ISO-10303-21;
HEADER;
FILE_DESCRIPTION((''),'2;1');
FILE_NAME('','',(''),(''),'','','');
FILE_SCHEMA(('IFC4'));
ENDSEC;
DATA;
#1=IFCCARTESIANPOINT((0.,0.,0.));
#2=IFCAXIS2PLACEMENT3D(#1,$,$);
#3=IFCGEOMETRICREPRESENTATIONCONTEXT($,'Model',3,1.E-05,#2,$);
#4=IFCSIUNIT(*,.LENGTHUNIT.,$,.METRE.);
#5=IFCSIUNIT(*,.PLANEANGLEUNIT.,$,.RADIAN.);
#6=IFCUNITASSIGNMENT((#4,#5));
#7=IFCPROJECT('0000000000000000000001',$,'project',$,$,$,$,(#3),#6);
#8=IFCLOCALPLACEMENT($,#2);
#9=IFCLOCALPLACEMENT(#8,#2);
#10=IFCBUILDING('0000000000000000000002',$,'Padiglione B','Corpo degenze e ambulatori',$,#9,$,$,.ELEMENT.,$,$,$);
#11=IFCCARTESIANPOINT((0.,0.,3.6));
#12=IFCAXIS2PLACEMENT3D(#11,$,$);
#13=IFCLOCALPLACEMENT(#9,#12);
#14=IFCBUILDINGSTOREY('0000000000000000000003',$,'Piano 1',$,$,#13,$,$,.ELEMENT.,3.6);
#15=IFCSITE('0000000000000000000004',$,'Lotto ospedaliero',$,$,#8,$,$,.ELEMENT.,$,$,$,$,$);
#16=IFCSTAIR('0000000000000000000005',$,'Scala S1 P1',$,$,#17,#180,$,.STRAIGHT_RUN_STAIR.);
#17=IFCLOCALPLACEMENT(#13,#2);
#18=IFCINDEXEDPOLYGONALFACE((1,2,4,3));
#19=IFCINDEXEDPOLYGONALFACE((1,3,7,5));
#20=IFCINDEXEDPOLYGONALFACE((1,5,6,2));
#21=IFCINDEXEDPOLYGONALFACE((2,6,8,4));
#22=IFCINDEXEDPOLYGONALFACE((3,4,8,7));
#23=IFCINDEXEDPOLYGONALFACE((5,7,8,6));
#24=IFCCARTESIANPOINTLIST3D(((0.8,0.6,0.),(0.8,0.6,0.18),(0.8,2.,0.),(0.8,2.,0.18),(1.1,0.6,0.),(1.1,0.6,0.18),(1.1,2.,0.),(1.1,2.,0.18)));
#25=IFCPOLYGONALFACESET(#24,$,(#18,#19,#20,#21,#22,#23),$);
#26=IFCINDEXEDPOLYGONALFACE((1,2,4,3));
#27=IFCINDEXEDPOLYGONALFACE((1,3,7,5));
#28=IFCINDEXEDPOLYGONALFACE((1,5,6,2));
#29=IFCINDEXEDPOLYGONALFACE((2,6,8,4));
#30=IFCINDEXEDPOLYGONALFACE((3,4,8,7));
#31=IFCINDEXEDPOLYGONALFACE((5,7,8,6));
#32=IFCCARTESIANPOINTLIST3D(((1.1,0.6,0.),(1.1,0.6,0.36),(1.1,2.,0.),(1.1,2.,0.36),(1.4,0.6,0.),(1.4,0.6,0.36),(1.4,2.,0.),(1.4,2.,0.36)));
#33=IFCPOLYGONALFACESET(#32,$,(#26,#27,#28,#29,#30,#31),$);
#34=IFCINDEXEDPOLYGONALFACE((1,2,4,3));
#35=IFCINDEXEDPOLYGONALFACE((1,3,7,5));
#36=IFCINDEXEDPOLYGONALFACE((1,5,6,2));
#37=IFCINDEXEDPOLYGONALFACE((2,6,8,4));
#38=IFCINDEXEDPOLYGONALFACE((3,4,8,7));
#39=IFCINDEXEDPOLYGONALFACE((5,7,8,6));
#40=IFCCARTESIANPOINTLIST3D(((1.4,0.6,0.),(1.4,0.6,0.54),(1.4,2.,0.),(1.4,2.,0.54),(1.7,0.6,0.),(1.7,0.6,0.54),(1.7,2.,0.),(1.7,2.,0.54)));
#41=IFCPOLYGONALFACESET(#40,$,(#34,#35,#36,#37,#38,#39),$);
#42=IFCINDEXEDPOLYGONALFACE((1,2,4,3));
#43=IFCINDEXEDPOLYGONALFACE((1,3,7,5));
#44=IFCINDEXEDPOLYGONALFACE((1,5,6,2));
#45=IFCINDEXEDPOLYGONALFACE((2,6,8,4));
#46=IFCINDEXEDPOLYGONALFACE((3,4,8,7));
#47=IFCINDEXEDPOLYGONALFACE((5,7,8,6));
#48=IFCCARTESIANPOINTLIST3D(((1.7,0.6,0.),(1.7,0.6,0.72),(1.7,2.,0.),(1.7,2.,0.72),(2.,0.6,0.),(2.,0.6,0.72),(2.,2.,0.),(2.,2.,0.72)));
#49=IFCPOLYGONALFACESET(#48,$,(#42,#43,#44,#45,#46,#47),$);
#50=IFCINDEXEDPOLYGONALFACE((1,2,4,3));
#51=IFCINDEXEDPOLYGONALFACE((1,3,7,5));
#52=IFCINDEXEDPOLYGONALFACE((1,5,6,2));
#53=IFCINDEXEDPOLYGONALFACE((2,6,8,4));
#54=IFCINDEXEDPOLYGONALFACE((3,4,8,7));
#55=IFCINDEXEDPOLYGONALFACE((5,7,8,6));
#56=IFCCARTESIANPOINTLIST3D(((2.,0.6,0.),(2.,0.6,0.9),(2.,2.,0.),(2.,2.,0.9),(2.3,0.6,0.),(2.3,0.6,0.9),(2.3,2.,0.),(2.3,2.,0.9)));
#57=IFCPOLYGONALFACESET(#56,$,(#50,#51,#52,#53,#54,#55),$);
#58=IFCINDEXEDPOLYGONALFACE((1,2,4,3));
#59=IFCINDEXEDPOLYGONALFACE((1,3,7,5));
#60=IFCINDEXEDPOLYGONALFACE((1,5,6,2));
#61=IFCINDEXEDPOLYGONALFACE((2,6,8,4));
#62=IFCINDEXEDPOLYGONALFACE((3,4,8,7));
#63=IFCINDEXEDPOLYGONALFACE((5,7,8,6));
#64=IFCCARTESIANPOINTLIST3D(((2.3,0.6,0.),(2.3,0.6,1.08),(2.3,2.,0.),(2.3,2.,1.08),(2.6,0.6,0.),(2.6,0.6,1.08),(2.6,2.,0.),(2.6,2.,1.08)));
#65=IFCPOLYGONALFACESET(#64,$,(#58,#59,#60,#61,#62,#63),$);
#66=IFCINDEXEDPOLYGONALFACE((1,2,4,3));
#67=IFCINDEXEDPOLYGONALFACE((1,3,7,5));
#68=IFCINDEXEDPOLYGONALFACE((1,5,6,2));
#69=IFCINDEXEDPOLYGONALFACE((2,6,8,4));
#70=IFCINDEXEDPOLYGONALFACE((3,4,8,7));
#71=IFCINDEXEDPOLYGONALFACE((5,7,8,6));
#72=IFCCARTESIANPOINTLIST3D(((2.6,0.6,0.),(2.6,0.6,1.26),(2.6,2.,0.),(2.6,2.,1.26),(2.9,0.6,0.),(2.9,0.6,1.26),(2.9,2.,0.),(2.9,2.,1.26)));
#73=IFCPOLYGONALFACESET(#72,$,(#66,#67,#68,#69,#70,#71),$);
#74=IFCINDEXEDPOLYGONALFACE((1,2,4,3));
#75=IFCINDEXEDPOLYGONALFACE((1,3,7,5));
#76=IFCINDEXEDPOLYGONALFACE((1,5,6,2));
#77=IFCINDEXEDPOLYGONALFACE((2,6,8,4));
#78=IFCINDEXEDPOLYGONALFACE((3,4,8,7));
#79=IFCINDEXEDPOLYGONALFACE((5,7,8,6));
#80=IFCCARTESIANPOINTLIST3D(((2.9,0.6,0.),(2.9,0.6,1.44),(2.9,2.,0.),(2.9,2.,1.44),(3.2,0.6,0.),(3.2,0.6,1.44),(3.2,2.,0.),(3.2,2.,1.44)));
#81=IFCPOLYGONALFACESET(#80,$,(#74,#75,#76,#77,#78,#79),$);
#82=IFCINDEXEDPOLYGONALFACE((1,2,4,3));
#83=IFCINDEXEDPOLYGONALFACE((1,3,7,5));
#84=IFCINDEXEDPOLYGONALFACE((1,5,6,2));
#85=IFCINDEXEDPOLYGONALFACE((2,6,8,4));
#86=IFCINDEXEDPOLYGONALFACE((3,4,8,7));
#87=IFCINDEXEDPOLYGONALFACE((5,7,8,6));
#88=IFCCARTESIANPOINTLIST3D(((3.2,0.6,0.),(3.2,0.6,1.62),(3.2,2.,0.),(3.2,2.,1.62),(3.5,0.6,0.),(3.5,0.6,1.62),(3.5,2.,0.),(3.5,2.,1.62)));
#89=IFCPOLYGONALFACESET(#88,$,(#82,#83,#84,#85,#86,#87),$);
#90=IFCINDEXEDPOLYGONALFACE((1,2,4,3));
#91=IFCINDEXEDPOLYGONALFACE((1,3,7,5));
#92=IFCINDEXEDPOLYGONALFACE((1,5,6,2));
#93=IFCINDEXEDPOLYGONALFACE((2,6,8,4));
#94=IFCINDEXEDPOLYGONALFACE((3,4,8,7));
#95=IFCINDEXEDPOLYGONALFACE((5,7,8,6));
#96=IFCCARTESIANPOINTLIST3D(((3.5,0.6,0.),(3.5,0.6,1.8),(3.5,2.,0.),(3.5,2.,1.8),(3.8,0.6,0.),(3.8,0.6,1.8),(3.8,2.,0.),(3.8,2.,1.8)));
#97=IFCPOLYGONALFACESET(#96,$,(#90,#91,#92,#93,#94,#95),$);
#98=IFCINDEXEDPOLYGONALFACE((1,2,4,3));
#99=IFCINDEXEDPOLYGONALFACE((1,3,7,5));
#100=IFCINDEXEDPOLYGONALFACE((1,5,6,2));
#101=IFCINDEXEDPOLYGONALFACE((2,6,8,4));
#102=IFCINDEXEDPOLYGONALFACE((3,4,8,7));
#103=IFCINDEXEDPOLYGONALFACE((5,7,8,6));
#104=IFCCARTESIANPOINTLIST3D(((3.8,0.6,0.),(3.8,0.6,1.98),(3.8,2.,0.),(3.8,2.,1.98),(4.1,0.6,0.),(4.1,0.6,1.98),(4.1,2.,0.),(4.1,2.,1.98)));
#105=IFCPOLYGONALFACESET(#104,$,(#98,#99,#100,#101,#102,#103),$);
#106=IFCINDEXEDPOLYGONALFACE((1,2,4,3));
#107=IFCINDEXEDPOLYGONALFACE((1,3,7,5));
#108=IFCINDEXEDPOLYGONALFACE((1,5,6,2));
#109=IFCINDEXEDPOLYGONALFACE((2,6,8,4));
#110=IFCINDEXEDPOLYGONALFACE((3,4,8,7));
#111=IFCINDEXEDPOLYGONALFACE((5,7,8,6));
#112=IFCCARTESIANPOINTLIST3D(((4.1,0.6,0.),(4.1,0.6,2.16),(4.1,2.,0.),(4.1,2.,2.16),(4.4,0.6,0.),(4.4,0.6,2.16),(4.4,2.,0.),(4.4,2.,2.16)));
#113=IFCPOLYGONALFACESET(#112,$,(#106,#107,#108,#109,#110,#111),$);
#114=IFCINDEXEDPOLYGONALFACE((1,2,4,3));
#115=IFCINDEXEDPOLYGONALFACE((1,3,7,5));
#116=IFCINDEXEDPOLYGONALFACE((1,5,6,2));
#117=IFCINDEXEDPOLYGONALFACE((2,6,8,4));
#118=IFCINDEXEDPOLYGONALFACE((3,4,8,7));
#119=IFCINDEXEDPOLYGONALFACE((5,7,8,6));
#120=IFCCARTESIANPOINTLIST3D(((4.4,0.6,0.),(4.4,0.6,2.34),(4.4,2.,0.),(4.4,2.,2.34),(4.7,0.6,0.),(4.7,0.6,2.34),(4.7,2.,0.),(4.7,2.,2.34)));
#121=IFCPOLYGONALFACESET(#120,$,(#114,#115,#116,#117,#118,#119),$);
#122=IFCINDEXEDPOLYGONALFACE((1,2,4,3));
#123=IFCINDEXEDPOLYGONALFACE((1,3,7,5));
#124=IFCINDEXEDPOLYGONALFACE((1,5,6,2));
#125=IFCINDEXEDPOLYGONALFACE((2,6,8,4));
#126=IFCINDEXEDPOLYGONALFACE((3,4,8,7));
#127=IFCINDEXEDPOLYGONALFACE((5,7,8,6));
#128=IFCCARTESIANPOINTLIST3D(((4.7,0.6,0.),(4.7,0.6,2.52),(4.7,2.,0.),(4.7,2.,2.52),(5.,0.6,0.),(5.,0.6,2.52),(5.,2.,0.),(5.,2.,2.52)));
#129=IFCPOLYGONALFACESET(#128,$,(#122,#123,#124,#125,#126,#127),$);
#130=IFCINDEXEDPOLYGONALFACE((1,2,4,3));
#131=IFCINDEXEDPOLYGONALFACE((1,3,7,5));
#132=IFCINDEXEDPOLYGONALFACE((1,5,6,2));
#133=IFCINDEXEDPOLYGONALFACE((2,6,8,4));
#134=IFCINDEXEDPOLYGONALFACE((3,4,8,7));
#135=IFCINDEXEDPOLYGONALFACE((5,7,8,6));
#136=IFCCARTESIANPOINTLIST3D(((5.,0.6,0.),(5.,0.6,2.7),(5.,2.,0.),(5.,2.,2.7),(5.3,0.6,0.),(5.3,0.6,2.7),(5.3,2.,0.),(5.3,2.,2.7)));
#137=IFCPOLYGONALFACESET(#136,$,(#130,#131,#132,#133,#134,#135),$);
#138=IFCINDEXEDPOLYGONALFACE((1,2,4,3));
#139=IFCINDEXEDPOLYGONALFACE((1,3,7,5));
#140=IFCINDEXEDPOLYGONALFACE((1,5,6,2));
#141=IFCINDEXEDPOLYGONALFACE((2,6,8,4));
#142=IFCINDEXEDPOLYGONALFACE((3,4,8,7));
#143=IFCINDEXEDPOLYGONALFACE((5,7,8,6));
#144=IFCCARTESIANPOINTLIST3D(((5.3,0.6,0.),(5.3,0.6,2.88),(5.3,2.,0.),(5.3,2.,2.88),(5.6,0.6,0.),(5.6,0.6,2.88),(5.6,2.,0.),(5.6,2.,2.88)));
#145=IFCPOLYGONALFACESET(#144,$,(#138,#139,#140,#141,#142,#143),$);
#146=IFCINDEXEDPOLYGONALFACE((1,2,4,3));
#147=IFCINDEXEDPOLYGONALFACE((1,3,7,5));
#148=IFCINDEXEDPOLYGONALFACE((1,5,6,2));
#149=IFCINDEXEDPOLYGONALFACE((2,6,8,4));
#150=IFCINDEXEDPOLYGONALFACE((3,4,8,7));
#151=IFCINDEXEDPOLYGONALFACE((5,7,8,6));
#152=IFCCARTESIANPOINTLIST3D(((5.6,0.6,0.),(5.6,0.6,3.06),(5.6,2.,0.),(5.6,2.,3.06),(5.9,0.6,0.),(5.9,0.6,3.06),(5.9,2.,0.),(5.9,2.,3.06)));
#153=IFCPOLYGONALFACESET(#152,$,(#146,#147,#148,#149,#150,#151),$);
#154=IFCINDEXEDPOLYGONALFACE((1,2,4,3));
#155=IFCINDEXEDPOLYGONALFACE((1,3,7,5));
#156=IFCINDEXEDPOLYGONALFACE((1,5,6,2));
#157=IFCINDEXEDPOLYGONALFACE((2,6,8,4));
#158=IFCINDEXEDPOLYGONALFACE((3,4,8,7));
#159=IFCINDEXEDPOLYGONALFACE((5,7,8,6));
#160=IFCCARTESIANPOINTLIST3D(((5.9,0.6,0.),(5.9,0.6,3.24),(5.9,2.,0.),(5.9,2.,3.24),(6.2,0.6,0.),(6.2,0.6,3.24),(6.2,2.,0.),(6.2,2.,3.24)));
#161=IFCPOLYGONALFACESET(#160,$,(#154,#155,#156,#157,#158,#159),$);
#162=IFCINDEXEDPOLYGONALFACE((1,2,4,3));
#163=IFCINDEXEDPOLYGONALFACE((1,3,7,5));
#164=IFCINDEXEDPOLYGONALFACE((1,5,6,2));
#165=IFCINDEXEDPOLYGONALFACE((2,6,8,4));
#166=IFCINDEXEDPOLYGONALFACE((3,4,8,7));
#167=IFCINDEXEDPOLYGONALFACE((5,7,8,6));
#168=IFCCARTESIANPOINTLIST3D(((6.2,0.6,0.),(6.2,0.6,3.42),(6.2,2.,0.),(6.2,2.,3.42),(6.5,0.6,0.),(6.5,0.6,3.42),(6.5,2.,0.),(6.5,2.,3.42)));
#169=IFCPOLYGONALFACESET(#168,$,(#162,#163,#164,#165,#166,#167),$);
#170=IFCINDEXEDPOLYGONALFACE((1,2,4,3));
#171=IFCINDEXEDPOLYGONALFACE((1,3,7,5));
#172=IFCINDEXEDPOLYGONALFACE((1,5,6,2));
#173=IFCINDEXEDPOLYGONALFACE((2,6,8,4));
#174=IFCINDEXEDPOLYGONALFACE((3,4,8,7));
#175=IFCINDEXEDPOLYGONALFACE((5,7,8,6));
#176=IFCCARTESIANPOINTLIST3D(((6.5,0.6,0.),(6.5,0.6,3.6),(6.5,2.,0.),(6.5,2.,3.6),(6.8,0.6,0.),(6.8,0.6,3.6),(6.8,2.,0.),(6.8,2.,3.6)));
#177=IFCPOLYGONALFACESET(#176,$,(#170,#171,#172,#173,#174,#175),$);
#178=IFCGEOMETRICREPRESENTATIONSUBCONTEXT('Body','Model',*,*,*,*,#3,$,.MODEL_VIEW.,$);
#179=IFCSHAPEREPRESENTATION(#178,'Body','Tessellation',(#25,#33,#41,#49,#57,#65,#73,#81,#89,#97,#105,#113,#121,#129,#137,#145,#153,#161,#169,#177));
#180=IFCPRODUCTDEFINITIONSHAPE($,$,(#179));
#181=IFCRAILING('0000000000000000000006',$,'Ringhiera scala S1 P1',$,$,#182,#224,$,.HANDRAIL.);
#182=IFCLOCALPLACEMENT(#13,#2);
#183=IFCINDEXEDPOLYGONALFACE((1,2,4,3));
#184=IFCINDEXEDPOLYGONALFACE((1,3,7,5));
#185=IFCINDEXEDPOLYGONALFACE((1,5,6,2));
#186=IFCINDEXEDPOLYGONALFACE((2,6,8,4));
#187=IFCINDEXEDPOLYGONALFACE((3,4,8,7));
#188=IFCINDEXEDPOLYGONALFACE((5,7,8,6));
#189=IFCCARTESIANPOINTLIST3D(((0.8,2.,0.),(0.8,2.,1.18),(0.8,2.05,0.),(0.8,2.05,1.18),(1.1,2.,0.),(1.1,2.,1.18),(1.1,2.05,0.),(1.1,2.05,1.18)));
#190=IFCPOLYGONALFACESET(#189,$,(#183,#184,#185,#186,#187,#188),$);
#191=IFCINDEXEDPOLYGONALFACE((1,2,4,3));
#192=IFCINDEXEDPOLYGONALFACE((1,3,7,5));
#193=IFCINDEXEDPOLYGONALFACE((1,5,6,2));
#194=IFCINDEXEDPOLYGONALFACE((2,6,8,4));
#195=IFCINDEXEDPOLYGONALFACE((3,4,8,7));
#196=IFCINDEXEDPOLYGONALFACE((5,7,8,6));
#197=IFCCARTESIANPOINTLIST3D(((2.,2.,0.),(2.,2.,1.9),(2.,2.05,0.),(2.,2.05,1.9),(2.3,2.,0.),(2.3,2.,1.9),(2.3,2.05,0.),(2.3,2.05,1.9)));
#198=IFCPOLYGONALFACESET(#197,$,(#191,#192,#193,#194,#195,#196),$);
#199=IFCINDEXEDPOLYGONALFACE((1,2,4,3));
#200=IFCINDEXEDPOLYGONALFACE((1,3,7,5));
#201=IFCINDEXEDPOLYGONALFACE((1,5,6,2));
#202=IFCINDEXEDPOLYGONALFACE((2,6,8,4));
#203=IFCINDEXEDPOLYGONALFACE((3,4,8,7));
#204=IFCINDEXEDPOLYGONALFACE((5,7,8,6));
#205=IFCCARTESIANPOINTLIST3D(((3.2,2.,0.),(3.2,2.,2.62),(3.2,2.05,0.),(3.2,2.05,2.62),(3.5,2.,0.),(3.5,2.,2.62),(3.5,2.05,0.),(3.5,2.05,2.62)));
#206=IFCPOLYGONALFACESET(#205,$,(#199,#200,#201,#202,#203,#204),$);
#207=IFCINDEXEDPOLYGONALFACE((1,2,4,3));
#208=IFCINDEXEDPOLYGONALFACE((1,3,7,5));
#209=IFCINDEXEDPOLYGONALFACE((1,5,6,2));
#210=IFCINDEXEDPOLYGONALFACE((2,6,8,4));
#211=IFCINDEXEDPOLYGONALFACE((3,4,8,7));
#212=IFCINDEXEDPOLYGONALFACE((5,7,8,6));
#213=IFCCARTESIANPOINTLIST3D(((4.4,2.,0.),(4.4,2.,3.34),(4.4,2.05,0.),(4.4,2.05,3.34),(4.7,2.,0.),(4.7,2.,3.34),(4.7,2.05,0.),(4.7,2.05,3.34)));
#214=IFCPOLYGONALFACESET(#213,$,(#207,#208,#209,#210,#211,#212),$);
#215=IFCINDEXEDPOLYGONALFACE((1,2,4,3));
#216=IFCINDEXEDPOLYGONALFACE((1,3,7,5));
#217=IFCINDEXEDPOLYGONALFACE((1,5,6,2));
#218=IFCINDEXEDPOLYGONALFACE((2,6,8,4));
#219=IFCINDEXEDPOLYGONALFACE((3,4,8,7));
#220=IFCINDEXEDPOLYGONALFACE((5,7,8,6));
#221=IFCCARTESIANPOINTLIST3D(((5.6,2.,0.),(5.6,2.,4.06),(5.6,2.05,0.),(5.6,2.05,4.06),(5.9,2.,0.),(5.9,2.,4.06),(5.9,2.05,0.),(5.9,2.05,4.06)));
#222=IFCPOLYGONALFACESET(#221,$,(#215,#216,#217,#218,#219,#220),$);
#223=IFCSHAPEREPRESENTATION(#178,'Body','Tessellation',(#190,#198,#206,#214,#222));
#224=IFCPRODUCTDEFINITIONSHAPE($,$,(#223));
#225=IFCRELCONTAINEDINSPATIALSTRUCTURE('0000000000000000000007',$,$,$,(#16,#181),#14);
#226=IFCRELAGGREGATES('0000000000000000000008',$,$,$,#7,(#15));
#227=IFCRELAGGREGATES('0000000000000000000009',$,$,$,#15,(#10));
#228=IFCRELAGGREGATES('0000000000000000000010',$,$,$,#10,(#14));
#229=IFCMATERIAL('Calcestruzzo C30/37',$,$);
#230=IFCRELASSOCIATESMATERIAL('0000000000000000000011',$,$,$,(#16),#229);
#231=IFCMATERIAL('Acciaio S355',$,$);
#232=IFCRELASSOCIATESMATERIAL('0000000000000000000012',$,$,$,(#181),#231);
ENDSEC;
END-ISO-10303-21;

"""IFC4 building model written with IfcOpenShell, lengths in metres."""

from ifc_helpers import new_model, si_unit, frame, frame_2d, origin, place, context, subcontext, project, spatial, rectangle, extrude, material, element, save


model = new_model("IFC4")

# Units and contexts
model_context = context("Model", 3, precision=1e-05, world=origin())
body_context = subcontext(model_context, "Body", "Model", "MODEL_VIEW")
ifc_project = project(units=[si_unit("LENGTHUNIT", "METRE"), si_unit("PLANEANGLEUNIT", "RADIAN")], contexts=[model_context])

# Site, building, storey
site_placement = place(None, origin())
site = spatial("IfcSite", under=ifc_project, at=site_placement, Name="Lotto ospedaliero", CompositionType="ELEMENT")
building_placement = place(site_placement, origin())
building = spatial("IfcBuilding", under=site, at=building_placement, Name="Padiglione B", Description="Corpo degenze e ambulatori", CompositionType="ELEMENT")
storey_placement = place(building_placement, frame((0.0, 0.0, 3.6)))
storey = spatial("IfcBuildingStorey", under=building, at=storey_placement, Name="Piano 1", CompositionType="ELEMENT", Elevation=3.6)

# Shared definitions
ifc_material_1 = material(Name="Calcestruzzo C30/37")

# Stair
stair_placement = place(storey_placement, frame((0.8, 0.6, 0.0)))
element("IfcStair", 1, at=stair_placement, inside=storey, material=ifc_material_1, Name="Scala S1 P1", PredefinedType="STRAIGHT_RUN_STAIR", context=body_context, shape_type="SweptSolid", body=[
    extrude(rectangle(XDim=0.3, YDim=1.4, at=frame_2d((0.15, 0.7))), origin(), (0.0, 0.0, 1.0), 0.18),
    extrude(rectangle(XDim=0.3, YDim=1.4, at=frame_2d((0.15, 0.7))), frame((0.3, 0.0, 0.0)), (0.0, 0.0, 1.0), 0.36),
    extrude(rectangle(XDim=0.3, YDim=1.4, at=frame_2d((0.15, 0.7))), frame((0.6, 0.0, 0.0)), (0.0, 0.0, 1.0), 0.54),
    extrude(rectangle(XDim=0.3, YDim=1.4, at=frame_2d((0.15, 0.7))), frame((0.9, 0.0, 0.0)), (0.0, 0.0, 1.0), 0.72),
    extrude(rectangle(XDim=0.3, YDim=1.4, at=frame_2d((0.15, 0.7))), frame((1.2, 0.0, 0.0)), (0.0, 0.0, 1.0), 0.9),
    extrude(rectangle(XDim=0.3, YDim=1.4, at=frame_2d((0.15, 0.7))), frame((1.5, 0.0, 0.0)), (0.0, 0.0, 1.0), 1.08),
    extrude(rectangle(XDim=0.3, YDim=1.4, at=frame_2d((0.15, 0.7))), frame((1.8, 0.0, 0.0)), (0.0, 0.0, 1.0), 1.26),
    extrude(rectangle(XDim=0.3, YDim=1.4, at=frame_2d((0.15, 0.7))), frame((2.1, 0.0, 0.0)), (0.0, 0.0, 1.0), 1.44),
    extrude(rectangle(XDim=0.3, YDim=1.4, at=frame_2d((0.15, 0.7))), frame((2.4, 0.0, 0.0)), (0.0, 0.0, 1.0), 1.62),
    extrude(rectangle(XDim=0.3, YDim=1.4, at=frame_2d((0.15, 0.7))), frame((2.7, 0.0, 0.0)), (0.0, 0.0, 1.0), 1.8),
    extrude(rectangle(XDim=0.3, YDim=1.4, at=frame_2d((0.15, 0.7))), frame((3.0, 0.0, 0.0)), (0.0, 0.0, 1.0), 1.98),
    extrude(rectangle(XDim=0.3, YDim=1.4, at=frame_2d((0.15, 0.7))), frame((3.3, 0.0, 0.0)), (0.0, 0.0, 1.0), 2.16),
    extrude(rectangle(XDim=0.3, YDim=1.4, at=frame_2d((0.15, 0.7))), frame((3.6, 0.0, 0.0)), (0.0, 0.0, 1.0), 2.34),
    extrude(rectangle(XDim=0.3, YDim=1.4, at=frame_2d((0.15, 0.7))), frame((3.9, 0.0, 0.0)), (0.0, 0.0, 1.0), 2.52),
    extrude(rectangle(XDim=0.3, YDim=1.4, at=frame_2d((0.15, 0.7))), frame((4.2, 0.0, 0.0)), (0.0, 0.0, 1.0), 2.7),
    extrude(rectangle(XDim=0.3, YDim=1.4, at=frame_2d((0.15, 0.7))), frame((4.5, 0.0, 0.0)), (0.0, 0.0, 1.0), 2.88),
    extrude(rectangle(XDim=0.3, YDim=1.4, at=frame_2d((0.15, 0.7))), frame((4.8, 0.0, 0.0)), (0.0, 0.0, 1.0), 3.06),
    extrude(rectangle(XDim=0.3, YDim=1.4, at=frame_2d((0.15, 0.7))), frame((5.1, 0.0, 0.0)), (0.0, 0.0, 1.0), 3.24),
    extrude(rectangle(XDim=0.3, YDim=1.4, at=frame_2d((0.15, 0.7))), frame((5.4, 0.0, 0.0)), (0.0, 0.0, 1.0), 3.42),
    extrude(rectangle(XDim=0.3, YDim=1.4, at=frame_2d((0.15, 0.7))), frame((5.7, 0.0, 0.0)), (0.0, 0.0, 1.0), 3.6),
])

# Railing
ifc_material_2 = material(Name="Acciaio S355")
railing_placement = place(storey_placement, frame((0.8, 2.0, 0.0)))
element("IfcRailing", 2, at=railing_placement, inside=storey, material=ifc_material_2, Name="Ringhiera scala S1 P1", PredefinedType="HANDRAIL", context=body_context, shape_type="SweptSolid", body=[
    extrude(rectangle(XDim=0.3, YDim=0.05, at=frame_2d((0.15, 0.025))), origin(), (0.0, 0.0, 1.0), 1.18),
    extrude(rectangle(XDim=0.3, YDim=0.05, at=frame_2d((0.15, 0.025))), frame((1.2, 0.0, 0.0)), (0.0, 0.0, 1.0), 1.9),
    extrude(rectangle(XDim=0.3, YDim=0.05, at=frame_2d((0.15, 0.025))), frame((2.4, 0.0, 0.0)), (0.0, 0.0, 1.0), 2.62),
    extrude(rectangle(XDim=0.3, YDim=0.05, at=frame_2d((0.15, 0.025))), frame((3.6, 0.0, 0.0)), (0.0, 0.0, 1.0), 3.34),
    extrude(rectangle(XDim=0.3, YDim=0.05, at=frame_2d((0.15, 0.025))), frame((4.8, 0.0, 0.0)), (0.0, 0.0, 1.0), 4.06),
])

save(model, "model.ifc")
